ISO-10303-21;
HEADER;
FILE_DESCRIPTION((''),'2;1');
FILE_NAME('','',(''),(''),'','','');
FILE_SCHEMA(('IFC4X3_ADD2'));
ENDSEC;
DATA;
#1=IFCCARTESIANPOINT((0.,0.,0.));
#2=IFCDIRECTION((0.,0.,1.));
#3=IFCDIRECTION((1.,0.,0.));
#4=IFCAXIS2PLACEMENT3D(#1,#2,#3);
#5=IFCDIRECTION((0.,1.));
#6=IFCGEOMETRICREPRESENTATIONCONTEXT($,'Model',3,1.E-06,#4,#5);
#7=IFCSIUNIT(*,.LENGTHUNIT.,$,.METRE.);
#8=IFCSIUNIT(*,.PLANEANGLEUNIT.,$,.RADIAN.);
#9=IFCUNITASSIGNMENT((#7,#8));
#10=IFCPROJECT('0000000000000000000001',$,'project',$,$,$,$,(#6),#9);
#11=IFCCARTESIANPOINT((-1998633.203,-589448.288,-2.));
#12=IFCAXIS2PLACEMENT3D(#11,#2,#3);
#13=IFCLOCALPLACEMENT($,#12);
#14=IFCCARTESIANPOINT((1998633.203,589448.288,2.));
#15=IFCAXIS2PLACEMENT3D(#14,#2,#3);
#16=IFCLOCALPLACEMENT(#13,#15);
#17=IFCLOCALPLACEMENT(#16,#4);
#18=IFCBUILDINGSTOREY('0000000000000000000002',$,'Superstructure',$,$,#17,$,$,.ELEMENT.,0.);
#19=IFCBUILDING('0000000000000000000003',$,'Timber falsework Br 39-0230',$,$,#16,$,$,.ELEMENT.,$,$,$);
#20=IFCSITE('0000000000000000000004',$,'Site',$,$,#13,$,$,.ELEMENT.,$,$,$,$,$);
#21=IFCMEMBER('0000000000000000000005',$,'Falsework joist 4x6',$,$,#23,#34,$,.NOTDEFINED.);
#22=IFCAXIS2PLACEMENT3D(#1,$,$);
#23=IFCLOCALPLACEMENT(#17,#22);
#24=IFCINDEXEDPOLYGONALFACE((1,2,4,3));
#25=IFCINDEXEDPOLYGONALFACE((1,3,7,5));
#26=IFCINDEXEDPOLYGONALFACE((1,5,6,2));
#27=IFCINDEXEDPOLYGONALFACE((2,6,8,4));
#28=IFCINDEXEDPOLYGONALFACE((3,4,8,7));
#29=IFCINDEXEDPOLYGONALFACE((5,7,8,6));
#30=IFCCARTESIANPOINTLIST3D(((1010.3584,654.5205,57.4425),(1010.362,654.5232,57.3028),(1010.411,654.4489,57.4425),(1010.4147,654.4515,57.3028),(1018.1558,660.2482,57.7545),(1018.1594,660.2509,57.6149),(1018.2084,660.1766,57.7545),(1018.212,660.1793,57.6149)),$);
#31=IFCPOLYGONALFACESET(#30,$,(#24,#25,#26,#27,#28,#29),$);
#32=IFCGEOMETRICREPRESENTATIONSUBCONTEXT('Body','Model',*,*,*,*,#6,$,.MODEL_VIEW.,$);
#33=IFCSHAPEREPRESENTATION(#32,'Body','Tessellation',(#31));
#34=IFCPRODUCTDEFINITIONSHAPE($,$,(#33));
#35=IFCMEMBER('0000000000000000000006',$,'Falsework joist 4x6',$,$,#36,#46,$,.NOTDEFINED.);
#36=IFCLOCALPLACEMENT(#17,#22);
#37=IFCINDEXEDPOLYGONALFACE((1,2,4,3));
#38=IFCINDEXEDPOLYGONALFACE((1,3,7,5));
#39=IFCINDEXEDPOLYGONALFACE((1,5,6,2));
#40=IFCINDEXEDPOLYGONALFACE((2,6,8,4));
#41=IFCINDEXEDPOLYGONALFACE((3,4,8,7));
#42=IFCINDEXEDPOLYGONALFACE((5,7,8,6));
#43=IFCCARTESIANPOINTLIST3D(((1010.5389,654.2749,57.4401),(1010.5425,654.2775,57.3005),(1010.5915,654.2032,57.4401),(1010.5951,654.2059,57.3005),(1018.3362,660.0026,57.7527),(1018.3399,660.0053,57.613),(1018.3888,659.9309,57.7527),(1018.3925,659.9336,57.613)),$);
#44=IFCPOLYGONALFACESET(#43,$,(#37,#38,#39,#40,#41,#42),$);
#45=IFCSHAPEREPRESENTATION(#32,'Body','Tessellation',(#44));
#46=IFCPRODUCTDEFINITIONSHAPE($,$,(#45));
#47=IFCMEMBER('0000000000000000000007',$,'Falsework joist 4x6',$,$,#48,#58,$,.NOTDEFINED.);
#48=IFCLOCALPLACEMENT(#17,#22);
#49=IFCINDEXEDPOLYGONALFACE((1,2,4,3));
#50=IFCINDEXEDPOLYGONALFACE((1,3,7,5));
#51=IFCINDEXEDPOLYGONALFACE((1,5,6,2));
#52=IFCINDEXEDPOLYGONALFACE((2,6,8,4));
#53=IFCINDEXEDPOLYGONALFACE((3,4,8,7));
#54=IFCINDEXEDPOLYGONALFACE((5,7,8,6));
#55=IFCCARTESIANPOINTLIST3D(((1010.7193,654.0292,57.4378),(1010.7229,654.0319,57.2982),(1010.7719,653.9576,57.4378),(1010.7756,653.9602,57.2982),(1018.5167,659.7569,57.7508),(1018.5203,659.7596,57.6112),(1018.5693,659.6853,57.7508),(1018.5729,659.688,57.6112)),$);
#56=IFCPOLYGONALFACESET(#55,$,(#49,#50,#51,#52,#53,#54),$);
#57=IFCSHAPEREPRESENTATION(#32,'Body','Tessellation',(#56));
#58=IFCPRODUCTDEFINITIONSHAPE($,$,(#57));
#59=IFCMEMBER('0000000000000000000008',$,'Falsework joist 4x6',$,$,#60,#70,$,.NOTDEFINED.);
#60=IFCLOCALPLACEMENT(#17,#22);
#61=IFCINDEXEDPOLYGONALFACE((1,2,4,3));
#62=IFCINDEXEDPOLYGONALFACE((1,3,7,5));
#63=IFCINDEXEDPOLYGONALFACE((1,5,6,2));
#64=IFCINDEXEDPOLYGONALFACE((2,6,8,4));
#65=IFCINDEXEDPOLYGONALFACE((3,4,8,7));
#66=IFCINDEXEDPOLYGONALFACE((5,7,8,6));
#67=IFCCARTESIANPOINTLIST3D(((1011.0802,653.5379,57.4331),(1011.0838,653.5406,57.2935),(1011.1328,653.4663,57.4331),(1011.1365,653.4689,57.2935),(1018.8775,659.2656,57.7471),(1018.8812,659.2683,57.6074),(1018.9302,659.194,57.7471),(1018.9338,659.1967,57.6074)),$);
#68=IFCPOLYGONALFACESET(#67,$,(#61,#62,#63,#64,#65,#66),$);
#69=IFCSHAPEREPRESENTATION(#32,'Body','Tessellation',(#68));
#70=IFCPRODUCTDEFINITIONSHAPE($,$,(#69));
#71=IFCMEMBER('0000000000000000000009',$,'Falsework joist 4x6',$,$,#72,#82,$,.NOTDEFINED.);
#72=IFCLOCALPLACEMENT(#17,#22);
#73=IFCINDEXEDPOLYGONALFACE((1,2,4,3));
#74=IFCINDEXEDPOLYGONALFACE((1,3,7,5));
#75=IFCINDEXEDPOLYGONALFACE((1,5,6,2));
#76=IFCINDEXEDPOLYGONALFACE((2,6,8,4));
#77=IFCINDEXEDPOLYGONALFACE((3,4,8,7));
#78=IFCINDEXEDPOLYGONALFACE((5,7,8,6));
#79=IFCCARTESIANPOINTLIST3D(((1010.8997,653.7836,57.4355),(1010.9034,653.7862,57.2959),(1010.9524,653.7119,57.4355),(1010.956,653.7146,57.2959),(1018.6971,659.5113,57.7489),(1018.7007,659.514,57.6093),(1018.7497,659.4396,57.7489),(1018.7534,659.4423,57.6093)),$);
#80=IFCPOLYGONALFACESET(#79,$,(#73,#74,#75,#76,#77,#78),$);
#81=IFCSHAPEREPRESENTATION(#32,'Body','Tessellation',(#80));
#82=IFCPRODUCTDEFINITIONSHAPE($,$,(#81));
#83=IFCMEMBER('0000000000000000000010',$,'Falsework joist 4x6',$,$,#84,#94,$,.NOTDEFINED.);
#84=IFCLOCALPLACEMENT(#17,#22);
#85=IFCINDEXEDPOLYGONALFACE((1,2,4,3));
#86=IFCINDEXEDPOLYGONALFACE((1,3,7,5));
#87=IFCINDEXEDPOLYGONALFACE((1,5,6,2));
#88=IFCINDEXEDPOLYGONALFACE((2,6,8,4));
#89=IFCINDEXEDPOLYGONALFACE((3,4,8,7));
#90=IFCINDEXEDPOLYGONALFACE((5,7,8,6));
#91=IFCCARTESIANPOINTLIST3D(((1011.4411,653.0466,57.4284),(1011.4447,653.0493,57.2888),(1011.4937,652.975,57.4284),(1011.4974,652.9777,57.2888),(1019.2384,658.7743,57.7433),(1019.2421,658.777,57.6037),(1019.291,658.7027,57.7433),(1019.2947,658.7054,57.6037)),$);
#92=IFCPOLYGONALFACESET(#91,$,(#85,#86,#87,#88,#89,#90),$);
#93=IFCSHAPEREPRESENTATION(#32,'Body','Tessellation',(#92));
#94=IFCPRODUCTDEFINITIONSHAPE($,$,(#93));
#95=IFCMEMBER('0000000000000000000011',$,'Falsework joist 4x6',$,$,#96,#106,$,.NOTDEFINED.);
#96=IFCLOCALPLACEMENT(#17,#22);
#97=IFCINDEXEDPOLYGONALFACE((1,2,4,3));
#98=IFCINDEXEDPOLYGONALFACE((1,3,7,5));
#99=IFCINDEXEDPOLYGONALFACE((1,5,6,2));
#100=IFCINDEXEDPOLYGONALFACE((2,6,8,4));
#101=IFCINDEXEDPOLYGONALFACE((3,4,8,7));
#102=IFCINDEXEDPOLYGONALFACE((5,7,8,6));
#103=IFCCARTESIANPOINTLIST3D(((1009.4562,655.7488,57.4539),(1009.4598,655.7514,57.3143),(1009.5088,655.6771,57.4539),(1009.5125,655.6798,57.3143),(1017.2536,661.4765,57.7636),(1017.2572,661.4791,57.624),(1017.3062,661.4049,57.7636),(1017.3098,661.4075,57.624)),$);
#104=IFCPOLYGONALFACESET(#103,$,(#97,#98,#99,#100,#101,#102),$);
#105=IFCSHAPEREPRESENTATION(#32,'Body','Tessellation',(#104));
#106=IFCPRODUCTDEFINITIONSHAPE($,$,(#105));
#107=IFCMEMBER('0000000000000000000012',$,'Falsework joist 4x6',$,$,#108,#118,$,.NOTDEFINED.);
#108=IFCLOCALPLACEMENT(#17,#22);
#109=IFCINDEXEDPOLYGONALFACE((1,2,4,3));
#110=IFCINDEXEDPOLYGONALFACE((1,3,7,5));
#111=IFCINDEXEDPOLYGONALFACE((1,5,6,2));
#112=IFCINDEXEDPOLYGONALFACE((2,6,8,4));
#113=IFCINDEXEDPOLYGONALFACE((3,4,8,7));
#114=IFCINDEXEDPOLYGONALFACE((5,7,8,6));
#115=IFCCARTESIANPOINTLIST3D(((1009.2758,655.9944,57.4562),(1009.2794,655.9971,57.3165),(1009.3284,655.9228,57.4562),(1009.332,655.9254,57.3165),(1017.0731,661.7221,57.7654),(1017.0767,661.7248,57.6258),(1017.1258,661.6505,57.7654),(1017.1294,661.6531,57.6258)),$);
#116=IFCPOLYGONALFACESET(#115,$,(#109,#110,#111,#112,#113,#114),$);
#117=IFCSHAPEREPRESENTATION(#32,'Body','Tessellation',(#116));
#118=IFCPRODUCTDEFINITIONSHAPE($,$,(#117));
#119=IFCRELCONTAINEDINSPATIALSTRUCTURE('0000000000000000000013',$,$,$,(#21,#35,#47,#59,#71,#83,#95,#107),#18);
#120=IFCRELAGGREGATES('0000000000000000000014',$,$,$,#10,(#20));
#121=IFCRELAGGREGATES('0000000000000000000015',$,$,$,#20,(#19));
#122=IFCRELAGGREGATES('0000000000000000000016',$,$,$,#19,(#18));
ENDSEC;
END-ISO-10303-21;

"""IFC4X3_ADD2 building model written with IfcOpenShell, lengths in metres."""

from ifc_helpers import new_model, si_unit, direction, frame, frame_2d, origin, origin_with_axes, place, context, subcontext, project, spatial, rectangle, extrude, element, save


model = new_model("IFC4X3_ADD2")

# Units and contexts
model_context = context("Model", 3, precision=1e-06, world=origin_with_axes(), true_north=direction((0.0, 1.0)))
body_context = subcontext(model_context, "Body", "Model", "MODEL_VIEW")
ifc_project = project(units=[si_unit("LENGTHUNIT", "METRE"), si_unit("PLANEANGLEUNIT", "RADIAN")], contexts=[model_context])

# Site, building, storey
site_placement = place(None, frame((-1998633.203, -589448.288, -2.0), z_axis=(0.0, 0.0, 1.0), x_axis=(1.0, 0.0, 0.0)))
site = spatial("IfcSite", under=ifc_project, at=site_placement, Name="Site", CompositionType="ELEMENT")
building_placement = place(site_placement, frame((1998633.203, 589448.288, 2.0), z_axis=(0.0, 0.0, 1.0), x_axis=(1.0, 0.0, 0.0)))
building = spatial("IfcBuilding", under=site, at=building_placement, Name="Timber falsework Br 39-0230", CompositionType="ELEMENT")
storey_placement = place(building_placement, origin_with_axes())
storey = spatial("IfcBuildingStorey", under=building, at=storey_placement, Name="Superstructure", CompositionType="ELEMENT", Elevation=0.0)

# Members
member_1_placement = place(storey_placement, frame((1010.3884, 654.4874, 57.3028), z_axis=(0.805509, 0.591705, 0.032238), x_axis=(-0.592013, 0.805928, 0.0)))
element("IfcMember", 1, at=member_1_placement, inside=storey, Name="Falsework joist 4x6", PredefinedType="NOTDEFINED", context=body_context, shape_type="SweptSolid", body=[
    extrude(rectangle(XDim=0.0889, YDim=0.1397, at=frame_2d((0.0, 0.0698))), origin(), (0.0, 0.0, 1.0), 9.68),
])
member_2_placement = place(storey_placement, frame((1010.5688, 654.2417, 57.3005), z_axis=(0.805508, 0.591705, 0.032286), x_axis=(-0.592013, 0.805928, 0.0)))
element("IfcMember", 2, at=member_2_placement, inside=storey, Name="Falsework joist 4x6", PredefinedType="NOTDEFINED", context=body_context, shape_type="SweptSolid", body=[
    extrude(rectangle(XDim=0.0889, YDim=0.1397, at=frame_2d((0.0, 0.0698))), origin(), (0.0, 0.0, 1.0), 9.68),
])
member_3_placement = place(storey_placement, frame((1010.7493, 653.9961, 57.2982), z_axis=(0.805507, 0.591704, 0.032334), x_axis=(-0.592013, 0.805928, 0.0)))
element("IfcMember", 3, at=member_3_placement, inside=storey, Name="Falsework joist 4x6", PredefinedType="NOTDEFINED", context=body_context, shape_type="SweptSolid", body=[
    extrude(rectangle(XDim=0.0889, YDim=0.1397, at=frame_2d((0.0, 0.0698))), origin(), (0.0, 0.0, 1.0), 9.6801),
])
member_4_placement = place(storey_placement, frame((1011.1101, 653.5048, 57.2935), z_axis=(0.805504, 0.591702, 0.03243), x_axis=(-0.592013, 0.805928, 0.0)))
element("IfcMember", 4, at=member_4_placement, inside=storey, Name="Falsework joist 4x6", PredefinedType="NOTDEFINED", context=body_context, shape_type="SweptSolid", body=[
    extrude(rectangle(XDim=0.0889, YDim=0.1397, at=frame_2d((0.0, 0.0698))), origin(), (0.0, 0.0, 1.0), 9.6801),
])
member_5_placement = place(storey_placement, frame((1010.9297, 653.7504, 57.2959), z_axis=(0.805506, 0.591703, 0.032382), x_axis=(-0.592013, 0.805928, 0.0)))
element("IfcMember", 5, at=member_5_placement, inside=storey, Name="Falsework joist 4x6", PredefinedType="NOTDEFINED", context=body_context, shape_type="SweptSolid", body=[
    extrude(rectangle(XDim=0.0889, YDim=0.1397, at=frame_2d((0.0, 0.0698))), origin(), (0.0, 0.0, 1.0), 9.6801),
])
member_6_placement = place(storey_placement, frame((1011.471, 653.0135, 57.2888), z_axis=(0.805502, 0.5917, 0.032526), x_axis=(-0.592013, 0.805928, 0.0)))
element("IfcMember", 6, at=member_6_placement, inside=storey, Name="Falsework joist 4x6", PredefinedType="NOTDEFINED", context=body_context, shape_type="SweptSolid", body=[
    extrude(rectangle(XDim=0.0889, YDim=0.1397, at=frame_2d((0.0, 0.0698))), origin(), (0.0, 0.0, 1.0), 9.6801),
])
member_7_placement = place(storey_placement, frame((1009.4861, 655.7156, 57.3143), z_axis=(0.805516, 0.59171, 0.031998), x_axis=(-0.592013, 0.805928, 0.0)))
element("IfcMember", 7, at=member_7_placement, inside=storey, Name="Falsework joist 4x6", PredefinedType="NOTDEFINED", context=body_context, shape_type="SweptSolid", body=[
    extrude(rectangle(XDim=0.0889, YDim=0.1397, at=frame_2d((0.0, 0.0698))), origin(), (0.0, 0.0, 1.0), 9.68),
])
member_8_placement = place(storey_placement, frame((1009.3057, 655.9612, 57.3165), z_axis=(0.805517, 0.591711, 0.03195), x_axis=(-0.592013, 0.805928, 0.0)))
element("IfcMember", 8, at=member_8_placement, inside=storey, Name="Falsework joist 4x6", PredefinedType="NOTDEFINED", context=body_context, shape_type="SweptSolid", body=[
    extrude(rectangle(XDim=0.0889, YDim=0.1397, at=frame_2d((0.0, 0.0698))), origin(), (0.0, 0.0, 1.0), 9.6799),
])

save(model, "model.ifc")
